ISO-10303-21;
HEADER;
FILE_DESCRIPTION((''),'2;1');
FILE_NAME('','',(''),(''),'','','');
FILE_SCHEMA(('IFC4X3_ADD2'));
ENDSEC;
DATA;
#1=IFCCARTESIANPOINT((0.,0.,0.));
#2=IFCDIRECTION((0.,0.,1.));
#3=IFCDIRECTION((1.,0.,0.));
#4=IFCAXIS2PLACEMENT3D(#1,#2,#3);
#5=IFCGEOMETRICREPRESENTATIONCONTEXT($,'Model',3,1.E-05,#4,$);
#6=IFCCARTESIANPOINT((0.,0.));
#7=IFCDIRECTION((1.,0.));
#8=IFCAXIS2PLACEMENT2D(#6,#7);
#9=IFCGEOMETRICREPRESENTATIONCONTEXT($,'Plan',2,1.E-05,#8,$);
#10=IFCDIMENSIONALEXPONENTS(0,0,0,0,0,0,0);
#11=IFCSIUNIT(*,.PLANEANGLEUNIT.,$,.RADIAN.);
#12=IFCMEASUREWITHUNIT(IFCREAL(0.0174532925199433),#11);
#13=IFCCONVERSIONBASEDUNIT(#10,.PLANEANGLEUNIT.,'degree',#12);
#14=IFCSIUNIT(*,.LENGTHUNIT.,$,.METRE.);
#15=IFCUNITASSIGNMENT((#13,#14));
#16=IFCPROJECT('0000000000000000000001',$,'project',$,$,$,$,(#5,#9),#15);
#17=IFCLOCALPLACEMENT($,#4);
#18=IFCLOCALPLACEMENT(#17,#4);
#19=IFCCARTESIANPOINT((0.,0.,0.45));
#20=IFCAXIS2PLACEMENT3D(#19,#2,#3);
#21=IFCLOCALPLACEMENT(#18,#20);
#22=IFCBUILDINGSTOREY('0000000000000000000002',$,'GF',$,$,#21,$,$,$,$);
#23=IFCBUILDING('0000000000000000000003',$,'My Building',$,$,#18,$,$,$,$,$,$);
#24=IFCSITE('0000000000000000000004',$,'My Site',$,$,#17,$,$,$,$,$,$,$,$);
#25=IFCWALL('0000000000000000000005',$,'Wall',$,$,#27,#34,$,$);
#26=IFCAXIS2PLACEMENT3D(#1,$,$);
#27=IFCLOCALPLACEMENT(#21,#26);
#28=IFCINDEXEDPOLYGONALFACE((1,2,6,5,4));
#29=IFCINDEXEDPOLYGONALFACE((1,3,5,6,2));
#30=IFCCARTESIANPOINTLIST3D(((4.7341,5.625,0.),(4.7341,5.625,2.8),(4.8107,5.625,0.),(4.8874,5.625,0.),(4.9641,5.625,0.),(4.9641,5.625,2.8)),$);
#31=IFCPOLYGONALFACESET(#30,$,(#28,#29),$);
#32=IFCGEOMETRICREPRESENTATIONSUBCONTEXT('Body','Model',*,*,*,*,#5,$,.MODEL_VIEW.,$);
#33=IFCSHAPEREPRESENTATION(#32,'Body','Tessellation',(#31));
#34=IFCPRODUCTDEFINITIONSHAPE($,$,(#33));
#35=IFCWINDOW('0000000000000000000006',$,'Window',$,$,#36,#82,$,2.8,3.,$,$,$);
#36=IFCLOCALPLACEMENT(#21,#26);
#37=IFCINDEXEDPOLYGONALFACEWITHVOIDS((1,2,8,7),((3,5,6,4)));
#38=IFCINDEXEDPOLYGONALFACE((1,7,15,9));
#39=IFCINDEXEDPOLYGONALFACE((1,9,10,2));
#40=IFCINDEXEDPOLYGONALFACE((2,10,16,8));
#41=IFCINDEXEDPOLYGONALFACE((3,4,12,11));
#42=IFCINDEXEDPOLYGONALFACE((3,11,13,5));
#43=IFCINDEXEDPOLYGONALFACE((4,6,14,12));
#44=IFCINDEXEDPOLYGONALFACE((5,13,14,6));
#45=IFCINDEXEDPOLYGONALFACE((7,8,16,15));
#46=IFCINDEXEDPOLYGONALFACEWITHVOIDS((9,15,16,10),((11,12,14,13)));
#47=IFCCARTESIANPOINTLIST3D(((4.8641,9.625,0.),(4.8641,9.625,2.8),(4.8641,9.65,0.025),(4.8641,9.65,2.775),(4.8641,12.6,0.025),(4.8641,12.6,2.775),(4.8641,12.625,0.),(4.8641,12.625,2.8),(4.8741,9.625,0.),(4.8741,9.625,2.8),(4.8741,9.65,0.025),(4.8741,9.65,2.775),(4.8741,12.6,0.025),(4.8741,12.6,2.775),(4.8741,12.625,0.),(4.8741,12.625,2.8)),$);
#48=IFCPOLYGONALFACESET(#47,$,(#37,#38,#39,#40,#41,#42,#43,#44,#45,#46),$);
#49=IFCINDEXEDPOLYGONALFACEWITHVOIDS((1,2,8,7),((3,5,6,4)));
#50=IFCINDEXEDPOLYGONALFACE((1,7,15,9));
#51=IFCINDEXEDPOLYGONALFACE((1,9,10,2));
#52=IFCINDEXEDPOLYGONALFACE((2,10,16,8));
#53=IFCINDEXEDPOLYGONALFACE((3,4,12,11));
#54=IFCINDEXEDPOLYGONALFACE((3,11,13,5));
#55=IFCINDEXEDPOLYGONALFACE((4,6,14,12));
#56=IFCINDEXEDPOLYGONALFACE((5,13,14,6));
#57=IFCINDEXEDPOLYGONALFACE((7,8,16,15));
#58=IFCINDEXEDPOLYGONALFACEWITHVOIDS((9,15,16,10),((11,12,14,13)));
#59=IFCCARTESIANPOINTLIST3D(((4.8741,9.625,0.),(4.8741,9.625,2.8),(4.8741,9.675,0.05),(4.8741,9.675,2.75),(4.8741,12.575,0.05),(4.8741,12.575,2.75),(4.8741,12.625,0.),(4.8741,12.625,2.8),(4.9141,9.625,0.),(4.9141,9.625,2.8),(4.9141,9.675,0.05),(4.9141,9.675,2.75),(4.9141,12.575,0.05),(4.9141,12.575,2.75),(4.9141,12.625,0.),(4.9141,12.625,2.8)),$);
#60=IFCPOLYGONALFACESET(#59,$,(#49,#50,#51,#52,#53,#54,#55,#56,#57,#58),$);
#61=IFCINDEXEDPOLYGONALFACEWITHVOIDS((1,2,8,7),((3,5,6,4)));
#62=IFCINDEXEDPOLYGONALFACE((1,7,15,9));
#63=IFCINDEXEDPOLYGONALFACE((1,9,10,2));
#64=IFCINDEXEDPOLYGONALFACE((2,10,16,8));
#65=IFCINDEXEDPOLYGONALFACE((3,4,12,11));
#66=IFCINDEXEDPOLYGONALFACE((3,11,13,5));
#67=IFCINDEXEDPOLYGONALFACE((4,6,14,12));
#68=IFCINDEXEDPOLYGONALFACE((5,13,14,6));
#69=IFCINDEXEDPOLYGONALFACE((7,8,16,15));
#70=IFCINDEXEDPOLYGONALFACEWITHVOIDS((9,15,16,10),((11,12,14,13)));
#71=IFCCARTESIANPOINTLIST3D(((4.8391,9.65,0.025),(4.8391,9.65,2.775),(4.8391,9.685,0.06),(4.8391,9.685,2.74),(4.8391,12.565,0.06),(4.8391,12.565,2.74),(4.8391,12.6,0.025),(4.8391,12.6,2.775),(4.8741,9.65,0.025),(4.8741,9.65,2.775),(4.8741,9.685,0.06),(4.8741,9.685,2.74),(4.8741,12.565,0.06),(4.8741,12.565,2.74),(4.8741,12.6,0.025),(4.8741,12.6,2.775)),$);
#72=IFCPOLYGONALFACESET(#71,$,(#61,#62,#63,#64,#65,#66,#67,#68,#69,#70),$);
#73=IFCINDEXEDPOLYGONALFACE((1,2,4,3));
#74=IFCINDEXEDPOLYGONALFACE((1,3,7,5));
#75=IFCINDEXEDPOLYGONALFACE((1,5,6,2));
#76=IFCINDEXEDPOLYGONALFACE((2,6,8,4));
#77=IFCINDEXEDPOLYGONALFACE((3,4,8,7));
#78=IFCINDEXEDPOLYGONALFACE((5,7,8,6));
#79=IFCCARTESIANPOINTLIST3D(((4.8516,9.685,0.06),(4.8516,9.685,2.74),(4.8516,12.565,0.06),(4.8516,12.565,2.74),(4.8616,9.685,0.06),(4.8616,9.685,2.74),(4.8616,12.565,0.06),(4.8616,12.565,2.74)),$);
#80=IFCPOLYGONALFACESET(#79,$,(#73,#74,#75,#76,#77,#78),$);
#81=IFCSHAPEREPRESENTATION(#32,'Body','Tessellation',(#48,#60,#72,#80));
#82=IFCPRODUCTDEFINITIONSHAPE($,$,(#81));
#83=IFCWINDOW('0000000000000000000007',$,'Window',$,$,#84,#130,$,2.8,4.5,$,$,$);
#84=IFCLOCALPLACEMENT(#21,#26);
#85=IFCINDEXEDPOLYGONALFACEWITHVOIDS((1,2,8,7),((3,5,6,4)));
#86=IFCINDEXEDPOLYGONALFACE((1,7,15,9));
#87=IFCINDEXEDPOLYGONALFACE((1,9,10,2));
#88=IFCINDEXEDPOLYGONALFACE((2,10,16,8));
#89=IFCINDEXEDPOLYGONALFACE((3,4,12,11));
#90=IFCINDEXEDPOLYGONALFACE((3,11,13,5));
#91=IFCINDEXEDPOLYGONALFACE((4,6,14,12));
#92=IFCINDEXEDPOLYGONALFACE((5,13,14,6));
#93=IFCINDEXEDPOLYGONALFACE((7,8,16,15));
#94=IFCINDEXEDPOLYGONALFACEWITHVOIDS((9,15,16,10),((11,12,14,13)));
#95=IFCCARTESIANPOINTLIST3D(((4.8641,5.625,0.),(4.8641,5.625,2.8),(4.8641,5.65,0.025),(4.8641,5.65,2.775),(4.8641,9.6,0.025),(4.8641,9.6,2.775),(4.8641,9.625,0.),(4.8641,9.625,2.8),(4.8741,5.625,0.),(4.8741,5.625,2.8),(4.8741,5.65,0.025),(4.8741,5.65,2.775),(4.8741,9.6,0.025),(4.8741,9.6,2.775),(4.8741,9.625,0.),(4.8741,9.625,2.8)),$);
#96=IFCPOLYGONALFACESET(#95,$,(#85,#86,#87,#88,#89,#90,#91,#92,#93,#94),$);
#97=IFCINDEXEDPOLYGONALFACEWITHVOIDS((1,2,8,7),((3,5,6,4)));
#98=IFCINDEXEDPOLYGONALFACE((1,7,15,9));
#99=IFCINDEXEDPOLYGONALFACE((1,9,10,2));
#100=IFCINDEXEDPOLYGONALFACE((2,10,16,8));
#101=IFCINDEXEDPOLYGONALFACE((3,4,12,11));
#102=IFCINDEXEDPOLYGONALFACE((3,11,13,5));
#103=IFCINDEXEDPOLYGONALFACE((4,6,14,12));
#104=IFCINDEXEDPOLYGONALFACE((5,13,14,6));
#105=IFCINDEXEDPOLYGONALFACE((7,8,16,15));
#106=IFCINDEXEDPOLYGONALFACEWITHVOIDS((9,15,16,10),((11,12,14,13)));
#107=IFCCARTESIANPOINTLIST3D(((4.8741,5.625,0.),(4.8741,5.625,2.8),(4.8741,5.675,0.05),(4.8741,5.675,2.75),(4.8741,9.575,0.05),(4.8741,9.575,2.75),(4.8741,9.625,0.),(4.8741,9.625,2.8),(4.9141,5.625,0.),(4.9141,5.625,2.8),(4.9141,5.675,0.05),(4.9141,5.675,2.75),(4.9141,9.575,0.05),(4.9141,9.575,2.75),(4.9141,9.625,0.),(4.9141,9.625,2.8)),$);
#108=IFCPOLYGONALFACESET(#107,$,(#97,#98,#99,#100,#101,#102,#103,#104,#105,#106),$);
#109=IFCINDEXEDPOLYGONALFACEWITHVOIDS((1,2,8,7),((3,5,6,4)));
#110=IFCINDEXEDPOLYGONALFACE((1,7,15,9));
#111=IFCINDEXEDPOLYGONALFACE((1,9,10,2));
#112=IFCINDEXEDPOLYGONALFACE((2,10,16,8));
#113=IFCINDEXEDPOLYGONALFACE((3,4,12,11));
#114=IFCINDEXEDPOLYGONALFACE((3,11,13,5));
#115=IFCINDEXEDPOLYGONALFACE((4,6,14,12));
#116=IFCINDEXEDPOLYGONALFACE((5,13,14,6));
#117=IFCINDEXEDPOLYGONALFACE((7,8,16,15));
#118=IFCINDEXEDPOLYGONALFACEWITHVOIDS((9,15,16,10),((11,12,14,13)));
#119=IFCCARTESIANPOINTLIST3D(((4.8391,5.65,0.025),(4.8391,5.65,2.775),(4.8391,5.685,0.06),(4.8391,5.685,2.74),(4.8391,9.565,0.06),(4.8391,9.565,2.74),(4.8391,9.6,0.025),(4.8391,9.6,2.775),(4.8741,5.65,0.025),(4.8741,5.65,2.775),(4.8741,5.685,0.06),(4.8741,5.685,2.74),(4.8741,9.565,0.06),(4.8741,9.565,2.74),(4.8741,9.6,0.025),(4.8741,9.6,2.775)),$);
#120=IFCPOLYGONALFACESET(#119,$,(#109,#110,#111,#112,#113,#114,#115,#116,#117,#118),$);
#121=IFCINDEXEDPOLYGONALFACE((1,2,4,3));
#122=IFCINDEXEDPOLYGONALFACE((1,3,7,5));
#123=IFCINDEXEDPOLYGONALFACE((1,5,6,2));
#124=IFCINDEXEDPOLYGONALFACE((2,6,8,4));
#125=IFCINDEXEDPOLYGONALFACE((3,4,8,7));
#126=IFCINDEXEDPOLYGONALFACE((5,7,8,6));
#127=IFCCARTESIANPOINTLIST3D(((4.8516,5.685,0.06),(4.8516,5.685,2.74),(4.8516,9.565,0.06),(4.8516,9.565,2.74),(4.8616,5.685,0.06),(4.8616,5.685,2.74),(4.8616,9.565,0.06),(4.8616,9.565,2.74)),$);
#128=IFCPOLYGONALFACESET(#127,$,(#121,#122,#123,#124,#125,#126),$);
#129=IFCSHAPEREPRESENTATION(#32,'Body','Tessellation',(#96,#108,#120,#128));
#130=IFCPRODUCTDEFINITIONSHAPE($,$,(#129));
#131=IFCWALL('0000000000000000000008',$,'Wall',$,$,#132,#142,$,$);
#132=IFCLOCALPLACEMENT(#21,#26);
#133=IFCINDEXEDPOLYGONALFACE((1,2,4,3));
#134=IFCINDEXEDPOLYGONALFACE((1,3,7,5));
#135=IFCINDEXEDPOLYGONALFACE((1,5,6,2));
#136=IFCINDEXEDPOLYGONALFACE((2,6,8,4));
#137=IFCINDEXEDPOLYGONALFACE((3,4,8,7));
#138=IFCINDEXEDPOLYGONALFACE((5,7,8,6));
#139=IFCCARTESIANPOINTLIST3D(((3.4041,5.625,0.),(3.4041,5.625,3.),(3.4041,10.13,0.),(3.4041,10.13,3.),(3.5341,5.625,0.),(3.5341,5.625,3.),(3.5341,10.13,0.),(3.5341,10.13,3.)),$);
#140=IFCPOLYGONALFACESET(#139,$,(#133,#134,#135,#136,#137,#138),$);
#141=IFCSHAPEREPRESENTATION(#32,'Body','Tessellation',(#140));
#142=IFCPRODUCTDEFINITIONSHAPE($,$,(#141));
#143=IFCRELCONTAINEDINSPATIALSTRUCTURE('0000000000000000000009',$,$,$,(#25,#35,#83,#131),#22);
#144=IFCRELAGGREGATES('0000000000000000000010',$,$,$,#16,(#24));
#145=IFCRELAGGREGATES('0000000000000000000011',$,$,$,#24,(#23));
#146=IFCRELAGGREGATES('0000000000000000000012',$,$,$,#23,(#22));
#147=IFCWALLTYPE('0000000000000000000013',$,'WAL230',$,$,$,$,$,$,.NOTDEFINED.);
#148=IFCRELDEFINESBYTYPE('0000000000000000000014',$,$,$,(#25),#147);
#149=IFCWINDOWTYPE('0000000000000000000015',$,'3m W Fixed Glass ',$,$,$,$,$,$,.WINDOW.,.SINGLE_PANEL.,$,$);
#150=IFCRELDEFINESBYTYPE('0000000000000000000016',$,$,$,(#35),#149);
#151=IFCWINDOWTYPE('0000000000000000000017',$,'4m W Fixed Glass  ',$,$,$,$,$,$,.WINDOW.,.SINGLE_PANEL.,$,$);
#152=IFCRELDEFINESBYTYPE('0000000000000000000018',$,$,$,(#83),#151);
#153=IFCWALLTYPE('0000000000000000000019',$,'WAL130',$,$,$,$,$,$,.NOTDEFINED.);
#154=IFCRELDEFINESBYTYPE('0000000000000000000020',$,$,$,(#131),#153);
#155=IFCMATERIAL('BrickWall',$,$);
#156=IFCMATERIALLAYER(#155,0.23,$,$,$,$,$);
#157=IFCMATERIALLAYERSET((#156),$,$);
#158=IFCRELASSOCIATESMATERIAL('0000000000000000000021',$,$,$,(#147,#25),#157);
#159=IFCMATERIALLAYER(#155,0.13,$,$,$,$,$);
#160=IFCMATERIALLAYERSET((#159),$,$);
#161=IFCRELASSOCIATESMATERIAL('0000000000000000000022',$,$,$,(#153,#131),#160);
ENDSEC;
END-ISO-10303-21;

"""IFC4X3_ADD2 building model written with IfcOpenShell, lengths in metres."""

from ifc_helpers import new_model, entity, si_unit, converted_unit, frame, origin_with_axes, origin_2d_with_axis, place, context, subcontext, project, spatial, line, indexed_curve, outline, extrude, shape, source, transform, mapped, material, layer, layer_set, layer_usage, type_object, type_shapes, element, fill, save


model = new_model("IFC4X3_ADD2")

# Units and contexts
model_context = context("Model", 3, precision=1e-05, world=origin_with_axes())
plan_context = context("Plan", 2, precision=1e-05, world=origin_2d_with_axis())
body_context_1 = subcontext(model_context, "Body", "Model", "MODEL_VIEW")
body_context_2 = subcontext(plan_context, "Body", "Plan", "PLAN_VIEW")
ifc_project = project(units=[converted_unit("PLANEANGLEUNIT", "degree", entity("IfcReal", 0.0174532925199433), si_unit("PLANEANGLEUNIT", "RADIAN"), dimensions=[0, 0, 0, 0, 0, 0, 0]), si_unit("LENGTHUNIT", "METRE")], contexts=[model_context, plan_context])

# Site, building, storey
site_placement = place(None, origin_with_axes())
site = spatial("IfcSite", under=ifc_project, at=site_placement, Name="My Site")
building_placement = place(site_placement, origin_with_axes())
building = spatial("IfcBuilding", under=site, at=building_placement, Name="My Building")
storey_placement = place(building_placement, frame((0.0, 0.0, 0.45), z_axis=(0.0, 0.0, 1.0), x_axis=(1.0, 0.0, 0.0)))
storey = spatial("IfcBuildingStorey", under=building, at=storey_placement, Name="GF")

# Shared definitions
ifc_material_1 = material(Name="BrickWall")
ifc_layer_1 = layer(ifc_material_1, 0.23)
ifc_layer_set_1 = layer_set([ifc_layer_1])
wall_type_1 = type_object("IfcWallType", Name="WAL230", PredefinedType="NOTDEFINED", material=ifc_layer_set_1)
shared_shape_1 = source(origin_with_axes(), body_context_1, "Body", "SweptSolid", [
    extrude(outline(indexed_curve([(0.0, 0.0), (4.0, 0.0), (4.0, 2.8), (0.0, 2.8)], segments=[line(1, 2, 3, 4, 1)])), frame((0.0, -0.6, 0.0), z_axis=(0.0, -1.0, 0.0), x_axis=(1.0, 0.0, 0.0)), (0.0, 0.0, -1.0), 1.2),
])
window_type_1 = type_object("IfcWindowType", Name="4m W Fixed Glass  ", PartitioningType="SINGLE_PANEL", PredefinedType="WINDOW")
shared_shape_2 = source(origin_with_axes(), body_context_1, "Body", "SweptSolid", [
    extrude(outline(indexed_curve([(0.0, 0.0), (4.0, 0.0), (4.0, 2.8), (0.0, 2.8)], segments=[line(1, 2, 3, 4, 1)]), holes=[indexed_curve([(0.025, 0.025), (3.975, 0.025), (3.975, 2.775), (0.025, 2.775)], segments=[line(1, 2, 3, 4, 1)])]), frame((0.0, 0.09, 0.0), z_axis=(0.0, -1.0, 0.0), x_axis=(1.0, 0.0, 0.0)), (0.0, 0.0, -1.0), 0.01),
    extrude(outline(indexed_curve([(0.0, 0.0), (4.0, 0.0), (4.0, 2.8), (0.0, 2.8)], segments=[line(1, 2, 3, 4, 1)]), holes=[indexed_curve([(0.05, 0.05), (3.95, 0.05), (3.95, 2.75), (0.05, 2.75)], segments=[line(1, 2, 3, 4, 1)])]), frame((0.0, 0.05, 0.0), z_axis=(0.0, -1.0, 0.0), x_axis=(1.0, 0.0, 0.0)), (0.0, 0.0, -1.0), 0.04),
    extrude(outline(indexed_curve([(0.0, 0.0), (3.95, 0.0), (3.95, 2.75), (0.0, 2.75)], segments=[line(1, 2, 3, 4, 1)]), holes=[indexed_curve([(0.035, 0.035), (3.915, 0.035), (3.915, 2.715), (0.035, 2.715)], segments=[line(1, 2, 3, 4, 1)])]), frame((0.025, 0.09, 0.025), z_axis=(0.0, -1.0, 0.0), x_axis=(1.0, 0.0, 0.0)), (0.0, 0.0, -1.0), 0.035),
    extrude(outline(indexed_curve([(0.035, 0.035), (3.915, 0.035), (3.915, 2.715), (0.035, 2.715)], segments=[line(1, 2, 3, 4, 1)])), frame((0.025, 0.1025, 0.025), z_axis=(0.0, -1.0, 0.0), x_axis=(1.0, 0.0, 0.0)), (0.0, 0.0, -1.0), 0.01),
])
shared_shape_3 = source(origin_with_axes(), body_context_2, "Body", "Curve2D", [
    entity("IfcIndexedPolyCurve", entity("IfcCartesianPointList2D", [[0.05, 0.05], [3.95, 0.05]])),
    entity("IfcIndexedPolyCurve", entity("IfcCartesianPointList2D", [[0.0, 0.1], [0.025, 0.1], [0.025, 0.09], [0.05, 0.09], [0.05, 0.05], [0.0, 0.05]]), [entity("IfcLineIndex", [1, 2, 3, 4, 5, 6, 1])]),
    entity("IfcIndexedPolyCurve", entity("IfcCartesianPointList2D", [[4.0, 0.1], [3.975, 0.1], [3.975, 0.09], [3.95, 0.09], [3.95, 0.05], [4.0, 0.05]]), [entity("IfcLineIndex", [1, 2, 3, 4, 5, 6, 1])]),
    entity("IfcIndexedPolyCurve", entity("IfcCartesianPointList2D", [[0.025, 0.09], [0.06, 0.09], [0.06, 0.125], [0.025, 0.125]]), [entity("IfcLineIndex", [1, 2, 3, 4, 1])]),
    entity("IfcIndexedPolyCurve", entity("IfcCartesianPointList2D", [[3.975, 0.09], [3.94, 0.09], [3.94, 0.125], [3.975, 0.125]]), [entity("IfcLineIndex", [1, 2, 3, 4, 1])]),
    entity("IfcIndexedPolyCurve", entity("IfcCartesianPointList2D", [[0.06, 0.09], [3.94, 0.09]])),
    entity("IfcIndexedPolyCurve", entity("IfcCartesianPointList2D", [[0.06, 0.125], [3.94, 0.125]])),
    entity("IfcIndexedPolyCurve", entity("IfcCartesianPointList2D", [[0.06, 0.1075], [3.94, 0.1075]])),
])
type_shapes(window_type_1, [shared_shape_2, shared_shape_3])

# Shared definitions
shared_shape_4 = source(origin_with_axes(), body_context_1, "Body", "SweptSolid", [
    extrude(outline(indexed_curve([(0.0, 0.0), (3.0, 0.0), (3.0, 2.8), (0.0, 2.8)], segments=[line(1, 2, 3, 4, 1)])), frame((0.0, -0.6, 0.0), z_axis=(0.0, -1.0, 0.0), x_axis=(1.0, 0.0, 0.0)), (0.0, 0.0, -1.0), 1.2),
])
window_type_2 = type_object("IfcWindowType", Name="3m W Fixed Glass ", PartitioningType="SINGLE_PANEL", PredefinedType="WINDOW")
shared_shape_5 = source(origin_with_axes(), body_context_1, "Body", "SweptSolid", [
    extrude(outline(indexed_curve([(0.0, 0.0), (3.0, 0.0), (3.0, 2.8), (0.0, 2.8)], segments=[line(1, 2, 3, 4, 1)]), holes=[indexed_curve([(0.025, 0.025), (2.975, 0.025), (2.975, 2.775), (0.025, 2.775)], segments=[line(1, 2, 3, 4, 1)])]), frame((0.0, 0.09, 0.0), z_axis=(0.0, -1.0, 0.0), x_axis=(1.0, 0.0, 0.0)), (0.0, 0.0, -1.0), 0.01),
    extrude(outline(indexed_curve([(0.0, 0.0), (3.0, 0.0), (3.0, 2.8), (0.0, 2.8)], segments=[line(1, 2, 3, 4, 1)]), holes=[indexed_curve([(0.05, 0.05), (2.95, 0.05), (2.95, 2.75), (0.05, 2.75)], segments=[line(1, 2, 3, 4, 1)])]), frame((0.0, 0.05, 0.0), z_axis=(0.0, -1.0, 0.0), x_axis=(1.0, 0.0, 0.0)), (0.0, 0.0, -1.0), 0.04),
    extrude(outline(indexed_curve([(0.0, 0.0), (2.95, 0.0), (2.95, 2.75), (0.0, 2.75)], segments=[line(1, 2, 3, 4, 1)]), holes=[indexed_curve([(0.035, 0.035), (2.915, 0.035), (2.915, 2.715), (0.035, 2.715)], segments=[line(1, 2, 3, 4, 1)])]), frame((0.025, 0.09, 0.025), z_axis=(0.0, -1.0, 0.0), x_axis=(1.0, 0.0, 0.0)), (0.0, 0.0, -1.0), 0.035),
    extrude(outline(indexed_curve([(0.035, 0.035), (2.915, 0.035), (2.915, 2.715), (0.035, 2.715)], segments=[line(1, 2, 3, 4, 1)])), frame((0.025, 0.1025, 0.025), z_axis=(0.0, -1.0, 0.0), x_axis=(1.0, 0.0, 0.0)), (0.0, 0.0, -1.0), 0.01),
])
shared_shape_6 = source(origin_with_axes(), body_context_2, "Body", "Curve2D", [
    entity("IfcIndexedPolyCurve", entity("IfcCartesianPointList2D", [[0.05, 0.05], [2.95, 0.05]])),
    entity("IfcIndexedPolyCurve", entity("IfcCartesianPointList2D", [[0.0, 0.1], [0.025, 0.1], [0.025, 0.09], [0.05, 0.09], [0.05, 0.05], [0.0, 0.05]]), [entity("IfcLineIndex", [1, 2, 3, 4, 5, 6, 1])]),
    entity("IfcIndexedPolyCurve", entity("IfcCartesianPointList2D", [[3.0, 0.1], [2.975, 0.1], [2.975, 0.09], [2.95, 0.09], [2.95, 0.05], [3.0, 0.05]]), [entity("IfcLineIndex", [1, 2, 3, 4, 5, 6, 1])]),
    entity("IfcIndexedPolyCurve", entity("IfcCartesianPointList2D", [[0.025, 0.09], [0.06, 0.09], [0.06, 0.125], [0.025, 0.125]]), [entity("IfcLineIndex", [1, 2, 3, 4, 1])]),
    entity("IfcIndexedPolyCurve", entity("IfcCartesianPointList2D", [[2.975, 0.09], [2.94, 0.09], [2.94, 0.125], [2.975, 0.125]]), [entity("IfcLineIndex", [1, 2, 3, 4, 1])]),
    entity("IfcIndexedPolyCurve", entity("IfcCartesianPointList2D", [[0.06, 0.09], [2.94, 0.09]])),
    entity("IfcIndexedPolyCurve", entity("IfcCartesianPointList2D", [[0.06, 0.125], [2.94, 0.125]])),
    entity("IfcIndexedPolyCurve", entity("IfcCartesianPointList2D", [[0.06, 0.1075], [2.94, 0.1075]])),
])
type_shapes(window_type_2, [shared_shape_5, shared_shape_6])

# Wall, openings, windows
ifc_layer_usage_1 = layer_usage(ifc_layer_set_1, "AXIS2", "POSITIVE", 0.0)
wall_1_placement = place(storey_placement, frame((4.9641, 5.625, 0.0), z_axis=(0.0, 0.0, 1.0), x_axis=(0.0, 1.0, 0.0)))
wall_1 = element("IfcWall", 1, at=wall_1_placement, inside=storey, type_object=wall_type_1, material=ifc_layer_usage_1, Name="Wall", context=body_context_1, shape_type="SweptSolid", body=[
    extrude(outline(indexed_curve([(0.0, 0.0), (0.0, 0.23), (0.0, 0.23), (0.0, 0.0), (0.0, 0.0)], self_intersect=False)), origin_with_axes(), (0.0, 0.0, 1.0), 2.8),
])
opening_1_placement = place(wall_1_placement, frame((4.0, 0.0, 0.0), z_axis=(0.0, 0.0, 1.0), x_axis=(1.0, 0.0, 0.0)))
opening_1 = element("IfcOpeningElement", 2, at=opening_1_placement, cuts=wall_1, PredefinedType="OPENING", context=body_context_1, shape_type="MappedRepresentation", body=[
    mapped(shared_shape_4, transform((0.0, 0.0, 0.0), x_axis=(1.0, 0.0, 0.0), y_axis=(0.0, 1.0, 0.0), z_axis=(0.0, 0.0, 1.0), scale=1.0)),
])
opening_2_placement = place(wall_1_placement, frame((0.0, 0.0, 0.0), z_axis=(0.0, 0.0, 1.0), x_axis=(1.0, 0.0, 0.0)))
opening_2 = element("IfcOpeningElement", 3, at=opening_2_placement, cuts=wall_1, PredefinedType="OPENING", context=body_context_1, shape_type="MappedRepresentation", body=[
    mapped(shared_shape_1, transform((0.0, 0.0, 0.0), x_axis=(1.0, 0.0, 0.0), y_axis=(0.0, 1.0, 0.0), z_axis=(0.0, 0.0, 1.0), scale=1.0)),
])
window_1_placement = place(opening_1_placement, frame((0.0, 0.0, 0.0), z_axis=(0.0, 0.0, 1.0), x_axis=(1.0, 0.0, 0.0)))
window_1 = element("IfcWindow", 4, at=window_1_placement, inside=storey, type_object=window_type_2, Name="Window", OverallHeight=2.8, OverallWidth=3.0, shapes=[
    shape(body_context_1, "Body", "MappedRepresentation", [mapped(shared_shape_5, transform((0.0, 0.0, 0.0), x_axis=(1.0, 0.0, 0.0), y_axis=(0.0, 1.0, 0.0), z_axis=(0.0, 0.0, 1.0), scale=1.0))]),
    shape(body_context_2, "Body", "MappedRepresentation", [mapped(shared_shape_6, transform((0.0, 0.0, 0.0), x_axis=(1.0, 0.0, 0.0), y_axis=(0.0, 1.0, 0.0), z_axis=(0.0, 0.0, 1.0), scale=1.0))]),
])
fill(opening_1, window_1)
window_2_placement = place(opening_2_placement, origin_with_axes())
window_2 = element("IfcWindow", 5, at=window_2_placement, inside=storey, type_object=window_type_1, Name="Window", OverallHeight=2.8, OverallWidth=4.5, shapes=[
    shape(body_context_1, "Body", "MappedRepresentation", [mapped(shared_shape_2, transform((0.0, 0.0, 0.0), x_axis=(1.0, 0.0, 0.0), y_axis=(0.0, 1.0, 0.0), z_axis=(0.0, 0.0, 1.0), scale=1.0))]),
    shape(body_context_2, "Body", "MappedRepresentation", [mapped(shared_shape_3, transform((0.0, 0.0, 0.0), x_axis=(1.0, 0.0, 0.0), y_axis=(0.0, 1.0, 0.0), z_axis=(0.0, 0.0, 1.0), scale=1.0))]),
])
fill(opening_2, window_2)

# Shared definitions
ifc_layer_2 = layer(ifc_material_1, 0.13)
ifc_layer_set_2 = layer_set([ifc_layer_2])
wall_type_2 = type_object("IfcWallType", Name="WAL130", PredefinedType="NOTDEFINED", material=ifc_layer_set_2)

# Wall
ifc_layer_usage_2 = layer_usage(ifc_layer_set_2, "AXIS2", "POSITIVE", 0.0)
wall_2_placement = place(storey_placement, frame((3.5341, 5.625, 0.0), z_axis=(0.0, 0.0, 1.0), x_axis=(0.0, 1.0, 0.0)))
element("IfcWall", 6, at=wall_2_placement, inside=storey, type_object=wall_type_2, material=ifc_layer_usage_2, Name="Wall", context=body_context_1, shape_type="SweptSolid", body=[
    extrude(outline(indexed_curve([(0.0, 0.0), (0.0, 0.13), (4.505, 0.13), (4.505, 0.0), (0.0, 0.0)], self_intersect=False)), origin_with_axes(), (0.0, 0.0, 1.0), 3.0),
])

save(model, "model.ifc")
